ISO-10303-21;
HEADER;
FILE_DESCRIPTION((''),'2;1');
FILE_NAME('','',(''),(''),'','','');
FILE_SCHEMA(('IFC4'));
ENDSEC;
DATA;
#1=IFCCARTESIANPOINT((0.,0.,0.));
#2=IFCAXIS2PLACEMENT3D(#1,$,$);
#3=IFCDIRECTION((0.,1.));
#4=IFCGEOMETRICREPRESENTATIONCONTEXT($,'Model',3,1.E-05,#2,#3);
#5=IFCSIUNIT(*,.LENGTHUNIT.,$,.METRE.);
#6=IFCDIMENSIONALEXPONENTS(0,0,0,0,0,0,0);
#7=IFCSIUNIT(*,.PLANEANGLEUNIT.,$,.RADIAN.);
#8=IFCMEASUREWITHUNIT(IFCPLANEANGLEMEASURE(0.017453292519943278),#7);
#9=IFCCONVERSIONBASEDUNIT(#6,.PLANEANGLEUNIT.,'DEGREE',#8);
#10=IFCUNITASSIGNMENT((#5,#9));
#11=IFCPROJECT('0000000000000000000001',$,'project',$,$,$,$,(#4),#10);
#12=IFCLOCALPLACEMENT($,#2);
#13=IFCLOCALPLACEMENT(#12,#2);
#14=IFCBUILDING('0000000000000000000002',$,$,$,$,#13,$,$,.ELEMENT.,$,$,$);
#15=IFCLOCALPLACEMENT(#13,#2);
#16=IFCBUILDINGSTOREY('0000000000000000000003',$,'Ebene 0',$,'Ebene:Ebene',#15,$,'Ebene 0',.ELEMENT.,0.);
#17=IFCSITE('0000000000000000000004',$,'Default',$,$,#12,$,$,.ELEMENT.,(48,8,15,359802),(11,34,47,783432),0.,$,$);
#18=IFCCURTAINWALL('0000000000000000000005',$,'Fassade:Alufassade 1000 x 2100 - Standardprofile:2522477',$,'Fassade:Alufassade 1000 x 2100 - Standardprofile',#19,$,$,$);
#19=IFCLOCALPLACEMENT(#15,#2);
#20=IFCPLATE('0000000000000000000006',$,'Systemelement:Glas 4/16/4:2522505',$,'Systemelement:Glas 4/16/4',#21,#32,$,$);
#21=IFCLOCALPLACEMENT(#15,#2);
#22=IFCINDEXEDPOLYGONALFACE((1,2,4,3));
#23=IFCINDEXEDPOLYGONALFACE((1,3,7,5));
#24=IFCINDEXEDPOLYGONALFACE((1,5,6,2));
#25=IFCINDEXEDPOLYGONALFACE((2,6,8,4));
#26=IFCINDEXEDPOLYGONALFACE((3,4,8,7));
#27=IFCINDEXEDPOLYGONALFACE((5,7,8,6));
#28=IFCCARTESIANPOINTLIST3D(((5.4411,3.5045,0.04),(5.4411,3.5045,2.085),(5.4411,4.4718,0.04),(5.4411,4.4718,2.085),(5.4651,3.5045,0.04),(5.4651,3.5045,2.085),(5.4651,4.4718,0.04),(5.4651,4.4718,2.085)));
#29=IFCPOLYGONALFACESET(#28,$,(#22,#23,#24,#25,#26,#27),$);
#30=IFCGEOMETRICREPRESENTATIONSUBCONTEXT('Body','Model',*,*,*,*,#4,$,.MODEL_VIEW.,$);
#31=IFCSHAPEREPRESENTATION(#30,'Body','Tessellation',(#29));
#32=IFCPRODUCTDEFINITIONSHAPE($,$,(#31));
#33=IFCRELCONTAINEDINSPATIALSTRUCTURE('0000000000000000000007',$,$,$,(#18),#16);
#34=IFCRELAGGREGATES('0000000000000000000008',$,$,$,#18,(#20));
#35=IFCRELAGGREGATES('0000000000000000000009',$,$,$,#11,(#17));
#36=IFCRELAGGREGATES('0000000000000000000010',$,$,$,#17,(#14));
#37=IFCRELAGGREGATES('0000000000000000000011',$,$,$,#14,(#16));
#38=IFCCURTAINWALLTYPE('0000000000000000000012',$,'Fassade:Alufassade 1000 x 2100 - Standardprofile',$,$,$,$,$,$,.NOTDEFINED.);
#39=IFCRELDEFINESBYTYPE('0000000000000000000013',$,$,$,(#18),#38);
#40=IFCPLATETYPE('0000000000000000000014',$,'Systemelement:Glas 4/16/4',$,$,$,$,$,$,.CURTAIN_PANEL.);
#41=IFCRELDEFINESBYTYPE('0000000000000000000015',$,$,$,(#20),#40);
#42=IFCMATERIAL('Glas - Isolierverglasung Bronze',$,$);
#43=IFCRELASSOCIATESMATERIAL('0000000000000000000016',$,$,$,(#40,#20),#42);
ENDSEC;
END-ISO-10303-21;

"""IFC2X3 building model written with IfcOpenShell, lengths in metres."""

from ifc_helpers import new_model, entity, si_unit, converted_unit, direction, frame, origin, origin_2d_with_axis, place, context, subcontext, project, spatial, rectangle, extrude, source, transform, mapped, material, type_object, type_shapes, element, aggregate, save


model = new_model("IFC2X3")

# Units and contexts
model_context = context("Model", 3, precision=1e-05, world=origin(), true_north=direction((0.0, 1.0)))
body_context = subcontext(model_context, "Body", "Model", "MODEL_VIEW")
ifc_project = project(units=[si_unit("LENGTHUNIT", "METRE"), converted_unit("PLANEANGLEUNIT", "DEGREE", entity("IfcPlaneAngleMeasure", 0.017453292519943278), si_unit("PLANEANGLEUNIT", "RADIAN"), dimensions=[0, 0, 0, 0, 0, 0, 0])], contexts=[model_context])

# Site, building, storey
site_placement = place(None, origin())
site = spatial("IfcSite", under=ifc_project, at=site_placement, Name="Default", CompositionType="ELEMENT", RefLatitude=(48, 8, 15, 359802), RefLongitude=(11, 34, 47, 783432), RefElevation=0.0)
building_placement = place(site_placement, origin())
building = spatial("IfcBuilding", under=site, at=building_placement, CompositionType="ELEMENT")
storey_placement = place(building_placement, origin())
storey = spatial("IfcBuildingStorey", under=building, at=storey_placement, Name="Ebene 0", ObjectType="Ebene:Ebene", LongName="Ebene 0", CompositionType="ELEMENT", Elevation=0.0)

# Curtain wall
curtain_wall_type = type_object("IfcCurtainWallType", Name="Fassade:Alufassade 1000 x 2100 - Standardprofile", PredefinedType="NOTDEFINED")
curtain_wall_1_placement = place(storey_placement, origin())
curtain_wall_1 = element("IfcCurtainWall", 1, at=curtain_wall_1_placement, inside=storey, type_object=curtain_wall_type, Name="Fassade:Alufassade 1000 x 2100 - Standardprofile:2522477", ObjectType="Fassade:Alufassade 1000 x 2100 - Standardprofile")

# Plate
ifc_material_1 = material(Name="Glas - Isolierverglasung Bronze")
plate_type = type_object("IfcPlateType", Name="Systemelement:Glas 4/16/4", PredefinedType="CURTAIN_PANEL", material=ifc_material_1)
shared_shape_1 = source(origin(), body_context, "Body", "SweptSolid", [
    extrude(rectangle(XDim=0.024, YDim=0.9673, at=origin_2d_with_axis()), frame((0.0, 0.0, 0.0), z_axis=(0.0, 0.0, 1.0), x_axis=(0.0, 1.0, 0.0)), (0.0, 0.0, 1.0), 2.045),
])
type_shapes(plate_type, [shared_shape_1])
plate_placement = place(curtain_wall_1_placement, frame((5.4531, 3.9882, 0.04), z_axis=(0.0, 0.0, 1.0), x_axis=(0.0, -1.0, 0.0)))
plate = element("IfcPlate", 2, at=plate_placement, type_object=plate_type, material=ifc_material_1, Name="Systemelement:Glas 4/16/4:2522505", ObjectType="Systemelement:Glas 4/16/4", context=body_context, shape_type="MappedRepresentation", body=[
    mapped(shared_shape_1, transform((0.0, 0.0, 0.0), scale=1.0)),
])
aggregate(curtain_wall_1, [plate])

save(model, "model.ifc")
